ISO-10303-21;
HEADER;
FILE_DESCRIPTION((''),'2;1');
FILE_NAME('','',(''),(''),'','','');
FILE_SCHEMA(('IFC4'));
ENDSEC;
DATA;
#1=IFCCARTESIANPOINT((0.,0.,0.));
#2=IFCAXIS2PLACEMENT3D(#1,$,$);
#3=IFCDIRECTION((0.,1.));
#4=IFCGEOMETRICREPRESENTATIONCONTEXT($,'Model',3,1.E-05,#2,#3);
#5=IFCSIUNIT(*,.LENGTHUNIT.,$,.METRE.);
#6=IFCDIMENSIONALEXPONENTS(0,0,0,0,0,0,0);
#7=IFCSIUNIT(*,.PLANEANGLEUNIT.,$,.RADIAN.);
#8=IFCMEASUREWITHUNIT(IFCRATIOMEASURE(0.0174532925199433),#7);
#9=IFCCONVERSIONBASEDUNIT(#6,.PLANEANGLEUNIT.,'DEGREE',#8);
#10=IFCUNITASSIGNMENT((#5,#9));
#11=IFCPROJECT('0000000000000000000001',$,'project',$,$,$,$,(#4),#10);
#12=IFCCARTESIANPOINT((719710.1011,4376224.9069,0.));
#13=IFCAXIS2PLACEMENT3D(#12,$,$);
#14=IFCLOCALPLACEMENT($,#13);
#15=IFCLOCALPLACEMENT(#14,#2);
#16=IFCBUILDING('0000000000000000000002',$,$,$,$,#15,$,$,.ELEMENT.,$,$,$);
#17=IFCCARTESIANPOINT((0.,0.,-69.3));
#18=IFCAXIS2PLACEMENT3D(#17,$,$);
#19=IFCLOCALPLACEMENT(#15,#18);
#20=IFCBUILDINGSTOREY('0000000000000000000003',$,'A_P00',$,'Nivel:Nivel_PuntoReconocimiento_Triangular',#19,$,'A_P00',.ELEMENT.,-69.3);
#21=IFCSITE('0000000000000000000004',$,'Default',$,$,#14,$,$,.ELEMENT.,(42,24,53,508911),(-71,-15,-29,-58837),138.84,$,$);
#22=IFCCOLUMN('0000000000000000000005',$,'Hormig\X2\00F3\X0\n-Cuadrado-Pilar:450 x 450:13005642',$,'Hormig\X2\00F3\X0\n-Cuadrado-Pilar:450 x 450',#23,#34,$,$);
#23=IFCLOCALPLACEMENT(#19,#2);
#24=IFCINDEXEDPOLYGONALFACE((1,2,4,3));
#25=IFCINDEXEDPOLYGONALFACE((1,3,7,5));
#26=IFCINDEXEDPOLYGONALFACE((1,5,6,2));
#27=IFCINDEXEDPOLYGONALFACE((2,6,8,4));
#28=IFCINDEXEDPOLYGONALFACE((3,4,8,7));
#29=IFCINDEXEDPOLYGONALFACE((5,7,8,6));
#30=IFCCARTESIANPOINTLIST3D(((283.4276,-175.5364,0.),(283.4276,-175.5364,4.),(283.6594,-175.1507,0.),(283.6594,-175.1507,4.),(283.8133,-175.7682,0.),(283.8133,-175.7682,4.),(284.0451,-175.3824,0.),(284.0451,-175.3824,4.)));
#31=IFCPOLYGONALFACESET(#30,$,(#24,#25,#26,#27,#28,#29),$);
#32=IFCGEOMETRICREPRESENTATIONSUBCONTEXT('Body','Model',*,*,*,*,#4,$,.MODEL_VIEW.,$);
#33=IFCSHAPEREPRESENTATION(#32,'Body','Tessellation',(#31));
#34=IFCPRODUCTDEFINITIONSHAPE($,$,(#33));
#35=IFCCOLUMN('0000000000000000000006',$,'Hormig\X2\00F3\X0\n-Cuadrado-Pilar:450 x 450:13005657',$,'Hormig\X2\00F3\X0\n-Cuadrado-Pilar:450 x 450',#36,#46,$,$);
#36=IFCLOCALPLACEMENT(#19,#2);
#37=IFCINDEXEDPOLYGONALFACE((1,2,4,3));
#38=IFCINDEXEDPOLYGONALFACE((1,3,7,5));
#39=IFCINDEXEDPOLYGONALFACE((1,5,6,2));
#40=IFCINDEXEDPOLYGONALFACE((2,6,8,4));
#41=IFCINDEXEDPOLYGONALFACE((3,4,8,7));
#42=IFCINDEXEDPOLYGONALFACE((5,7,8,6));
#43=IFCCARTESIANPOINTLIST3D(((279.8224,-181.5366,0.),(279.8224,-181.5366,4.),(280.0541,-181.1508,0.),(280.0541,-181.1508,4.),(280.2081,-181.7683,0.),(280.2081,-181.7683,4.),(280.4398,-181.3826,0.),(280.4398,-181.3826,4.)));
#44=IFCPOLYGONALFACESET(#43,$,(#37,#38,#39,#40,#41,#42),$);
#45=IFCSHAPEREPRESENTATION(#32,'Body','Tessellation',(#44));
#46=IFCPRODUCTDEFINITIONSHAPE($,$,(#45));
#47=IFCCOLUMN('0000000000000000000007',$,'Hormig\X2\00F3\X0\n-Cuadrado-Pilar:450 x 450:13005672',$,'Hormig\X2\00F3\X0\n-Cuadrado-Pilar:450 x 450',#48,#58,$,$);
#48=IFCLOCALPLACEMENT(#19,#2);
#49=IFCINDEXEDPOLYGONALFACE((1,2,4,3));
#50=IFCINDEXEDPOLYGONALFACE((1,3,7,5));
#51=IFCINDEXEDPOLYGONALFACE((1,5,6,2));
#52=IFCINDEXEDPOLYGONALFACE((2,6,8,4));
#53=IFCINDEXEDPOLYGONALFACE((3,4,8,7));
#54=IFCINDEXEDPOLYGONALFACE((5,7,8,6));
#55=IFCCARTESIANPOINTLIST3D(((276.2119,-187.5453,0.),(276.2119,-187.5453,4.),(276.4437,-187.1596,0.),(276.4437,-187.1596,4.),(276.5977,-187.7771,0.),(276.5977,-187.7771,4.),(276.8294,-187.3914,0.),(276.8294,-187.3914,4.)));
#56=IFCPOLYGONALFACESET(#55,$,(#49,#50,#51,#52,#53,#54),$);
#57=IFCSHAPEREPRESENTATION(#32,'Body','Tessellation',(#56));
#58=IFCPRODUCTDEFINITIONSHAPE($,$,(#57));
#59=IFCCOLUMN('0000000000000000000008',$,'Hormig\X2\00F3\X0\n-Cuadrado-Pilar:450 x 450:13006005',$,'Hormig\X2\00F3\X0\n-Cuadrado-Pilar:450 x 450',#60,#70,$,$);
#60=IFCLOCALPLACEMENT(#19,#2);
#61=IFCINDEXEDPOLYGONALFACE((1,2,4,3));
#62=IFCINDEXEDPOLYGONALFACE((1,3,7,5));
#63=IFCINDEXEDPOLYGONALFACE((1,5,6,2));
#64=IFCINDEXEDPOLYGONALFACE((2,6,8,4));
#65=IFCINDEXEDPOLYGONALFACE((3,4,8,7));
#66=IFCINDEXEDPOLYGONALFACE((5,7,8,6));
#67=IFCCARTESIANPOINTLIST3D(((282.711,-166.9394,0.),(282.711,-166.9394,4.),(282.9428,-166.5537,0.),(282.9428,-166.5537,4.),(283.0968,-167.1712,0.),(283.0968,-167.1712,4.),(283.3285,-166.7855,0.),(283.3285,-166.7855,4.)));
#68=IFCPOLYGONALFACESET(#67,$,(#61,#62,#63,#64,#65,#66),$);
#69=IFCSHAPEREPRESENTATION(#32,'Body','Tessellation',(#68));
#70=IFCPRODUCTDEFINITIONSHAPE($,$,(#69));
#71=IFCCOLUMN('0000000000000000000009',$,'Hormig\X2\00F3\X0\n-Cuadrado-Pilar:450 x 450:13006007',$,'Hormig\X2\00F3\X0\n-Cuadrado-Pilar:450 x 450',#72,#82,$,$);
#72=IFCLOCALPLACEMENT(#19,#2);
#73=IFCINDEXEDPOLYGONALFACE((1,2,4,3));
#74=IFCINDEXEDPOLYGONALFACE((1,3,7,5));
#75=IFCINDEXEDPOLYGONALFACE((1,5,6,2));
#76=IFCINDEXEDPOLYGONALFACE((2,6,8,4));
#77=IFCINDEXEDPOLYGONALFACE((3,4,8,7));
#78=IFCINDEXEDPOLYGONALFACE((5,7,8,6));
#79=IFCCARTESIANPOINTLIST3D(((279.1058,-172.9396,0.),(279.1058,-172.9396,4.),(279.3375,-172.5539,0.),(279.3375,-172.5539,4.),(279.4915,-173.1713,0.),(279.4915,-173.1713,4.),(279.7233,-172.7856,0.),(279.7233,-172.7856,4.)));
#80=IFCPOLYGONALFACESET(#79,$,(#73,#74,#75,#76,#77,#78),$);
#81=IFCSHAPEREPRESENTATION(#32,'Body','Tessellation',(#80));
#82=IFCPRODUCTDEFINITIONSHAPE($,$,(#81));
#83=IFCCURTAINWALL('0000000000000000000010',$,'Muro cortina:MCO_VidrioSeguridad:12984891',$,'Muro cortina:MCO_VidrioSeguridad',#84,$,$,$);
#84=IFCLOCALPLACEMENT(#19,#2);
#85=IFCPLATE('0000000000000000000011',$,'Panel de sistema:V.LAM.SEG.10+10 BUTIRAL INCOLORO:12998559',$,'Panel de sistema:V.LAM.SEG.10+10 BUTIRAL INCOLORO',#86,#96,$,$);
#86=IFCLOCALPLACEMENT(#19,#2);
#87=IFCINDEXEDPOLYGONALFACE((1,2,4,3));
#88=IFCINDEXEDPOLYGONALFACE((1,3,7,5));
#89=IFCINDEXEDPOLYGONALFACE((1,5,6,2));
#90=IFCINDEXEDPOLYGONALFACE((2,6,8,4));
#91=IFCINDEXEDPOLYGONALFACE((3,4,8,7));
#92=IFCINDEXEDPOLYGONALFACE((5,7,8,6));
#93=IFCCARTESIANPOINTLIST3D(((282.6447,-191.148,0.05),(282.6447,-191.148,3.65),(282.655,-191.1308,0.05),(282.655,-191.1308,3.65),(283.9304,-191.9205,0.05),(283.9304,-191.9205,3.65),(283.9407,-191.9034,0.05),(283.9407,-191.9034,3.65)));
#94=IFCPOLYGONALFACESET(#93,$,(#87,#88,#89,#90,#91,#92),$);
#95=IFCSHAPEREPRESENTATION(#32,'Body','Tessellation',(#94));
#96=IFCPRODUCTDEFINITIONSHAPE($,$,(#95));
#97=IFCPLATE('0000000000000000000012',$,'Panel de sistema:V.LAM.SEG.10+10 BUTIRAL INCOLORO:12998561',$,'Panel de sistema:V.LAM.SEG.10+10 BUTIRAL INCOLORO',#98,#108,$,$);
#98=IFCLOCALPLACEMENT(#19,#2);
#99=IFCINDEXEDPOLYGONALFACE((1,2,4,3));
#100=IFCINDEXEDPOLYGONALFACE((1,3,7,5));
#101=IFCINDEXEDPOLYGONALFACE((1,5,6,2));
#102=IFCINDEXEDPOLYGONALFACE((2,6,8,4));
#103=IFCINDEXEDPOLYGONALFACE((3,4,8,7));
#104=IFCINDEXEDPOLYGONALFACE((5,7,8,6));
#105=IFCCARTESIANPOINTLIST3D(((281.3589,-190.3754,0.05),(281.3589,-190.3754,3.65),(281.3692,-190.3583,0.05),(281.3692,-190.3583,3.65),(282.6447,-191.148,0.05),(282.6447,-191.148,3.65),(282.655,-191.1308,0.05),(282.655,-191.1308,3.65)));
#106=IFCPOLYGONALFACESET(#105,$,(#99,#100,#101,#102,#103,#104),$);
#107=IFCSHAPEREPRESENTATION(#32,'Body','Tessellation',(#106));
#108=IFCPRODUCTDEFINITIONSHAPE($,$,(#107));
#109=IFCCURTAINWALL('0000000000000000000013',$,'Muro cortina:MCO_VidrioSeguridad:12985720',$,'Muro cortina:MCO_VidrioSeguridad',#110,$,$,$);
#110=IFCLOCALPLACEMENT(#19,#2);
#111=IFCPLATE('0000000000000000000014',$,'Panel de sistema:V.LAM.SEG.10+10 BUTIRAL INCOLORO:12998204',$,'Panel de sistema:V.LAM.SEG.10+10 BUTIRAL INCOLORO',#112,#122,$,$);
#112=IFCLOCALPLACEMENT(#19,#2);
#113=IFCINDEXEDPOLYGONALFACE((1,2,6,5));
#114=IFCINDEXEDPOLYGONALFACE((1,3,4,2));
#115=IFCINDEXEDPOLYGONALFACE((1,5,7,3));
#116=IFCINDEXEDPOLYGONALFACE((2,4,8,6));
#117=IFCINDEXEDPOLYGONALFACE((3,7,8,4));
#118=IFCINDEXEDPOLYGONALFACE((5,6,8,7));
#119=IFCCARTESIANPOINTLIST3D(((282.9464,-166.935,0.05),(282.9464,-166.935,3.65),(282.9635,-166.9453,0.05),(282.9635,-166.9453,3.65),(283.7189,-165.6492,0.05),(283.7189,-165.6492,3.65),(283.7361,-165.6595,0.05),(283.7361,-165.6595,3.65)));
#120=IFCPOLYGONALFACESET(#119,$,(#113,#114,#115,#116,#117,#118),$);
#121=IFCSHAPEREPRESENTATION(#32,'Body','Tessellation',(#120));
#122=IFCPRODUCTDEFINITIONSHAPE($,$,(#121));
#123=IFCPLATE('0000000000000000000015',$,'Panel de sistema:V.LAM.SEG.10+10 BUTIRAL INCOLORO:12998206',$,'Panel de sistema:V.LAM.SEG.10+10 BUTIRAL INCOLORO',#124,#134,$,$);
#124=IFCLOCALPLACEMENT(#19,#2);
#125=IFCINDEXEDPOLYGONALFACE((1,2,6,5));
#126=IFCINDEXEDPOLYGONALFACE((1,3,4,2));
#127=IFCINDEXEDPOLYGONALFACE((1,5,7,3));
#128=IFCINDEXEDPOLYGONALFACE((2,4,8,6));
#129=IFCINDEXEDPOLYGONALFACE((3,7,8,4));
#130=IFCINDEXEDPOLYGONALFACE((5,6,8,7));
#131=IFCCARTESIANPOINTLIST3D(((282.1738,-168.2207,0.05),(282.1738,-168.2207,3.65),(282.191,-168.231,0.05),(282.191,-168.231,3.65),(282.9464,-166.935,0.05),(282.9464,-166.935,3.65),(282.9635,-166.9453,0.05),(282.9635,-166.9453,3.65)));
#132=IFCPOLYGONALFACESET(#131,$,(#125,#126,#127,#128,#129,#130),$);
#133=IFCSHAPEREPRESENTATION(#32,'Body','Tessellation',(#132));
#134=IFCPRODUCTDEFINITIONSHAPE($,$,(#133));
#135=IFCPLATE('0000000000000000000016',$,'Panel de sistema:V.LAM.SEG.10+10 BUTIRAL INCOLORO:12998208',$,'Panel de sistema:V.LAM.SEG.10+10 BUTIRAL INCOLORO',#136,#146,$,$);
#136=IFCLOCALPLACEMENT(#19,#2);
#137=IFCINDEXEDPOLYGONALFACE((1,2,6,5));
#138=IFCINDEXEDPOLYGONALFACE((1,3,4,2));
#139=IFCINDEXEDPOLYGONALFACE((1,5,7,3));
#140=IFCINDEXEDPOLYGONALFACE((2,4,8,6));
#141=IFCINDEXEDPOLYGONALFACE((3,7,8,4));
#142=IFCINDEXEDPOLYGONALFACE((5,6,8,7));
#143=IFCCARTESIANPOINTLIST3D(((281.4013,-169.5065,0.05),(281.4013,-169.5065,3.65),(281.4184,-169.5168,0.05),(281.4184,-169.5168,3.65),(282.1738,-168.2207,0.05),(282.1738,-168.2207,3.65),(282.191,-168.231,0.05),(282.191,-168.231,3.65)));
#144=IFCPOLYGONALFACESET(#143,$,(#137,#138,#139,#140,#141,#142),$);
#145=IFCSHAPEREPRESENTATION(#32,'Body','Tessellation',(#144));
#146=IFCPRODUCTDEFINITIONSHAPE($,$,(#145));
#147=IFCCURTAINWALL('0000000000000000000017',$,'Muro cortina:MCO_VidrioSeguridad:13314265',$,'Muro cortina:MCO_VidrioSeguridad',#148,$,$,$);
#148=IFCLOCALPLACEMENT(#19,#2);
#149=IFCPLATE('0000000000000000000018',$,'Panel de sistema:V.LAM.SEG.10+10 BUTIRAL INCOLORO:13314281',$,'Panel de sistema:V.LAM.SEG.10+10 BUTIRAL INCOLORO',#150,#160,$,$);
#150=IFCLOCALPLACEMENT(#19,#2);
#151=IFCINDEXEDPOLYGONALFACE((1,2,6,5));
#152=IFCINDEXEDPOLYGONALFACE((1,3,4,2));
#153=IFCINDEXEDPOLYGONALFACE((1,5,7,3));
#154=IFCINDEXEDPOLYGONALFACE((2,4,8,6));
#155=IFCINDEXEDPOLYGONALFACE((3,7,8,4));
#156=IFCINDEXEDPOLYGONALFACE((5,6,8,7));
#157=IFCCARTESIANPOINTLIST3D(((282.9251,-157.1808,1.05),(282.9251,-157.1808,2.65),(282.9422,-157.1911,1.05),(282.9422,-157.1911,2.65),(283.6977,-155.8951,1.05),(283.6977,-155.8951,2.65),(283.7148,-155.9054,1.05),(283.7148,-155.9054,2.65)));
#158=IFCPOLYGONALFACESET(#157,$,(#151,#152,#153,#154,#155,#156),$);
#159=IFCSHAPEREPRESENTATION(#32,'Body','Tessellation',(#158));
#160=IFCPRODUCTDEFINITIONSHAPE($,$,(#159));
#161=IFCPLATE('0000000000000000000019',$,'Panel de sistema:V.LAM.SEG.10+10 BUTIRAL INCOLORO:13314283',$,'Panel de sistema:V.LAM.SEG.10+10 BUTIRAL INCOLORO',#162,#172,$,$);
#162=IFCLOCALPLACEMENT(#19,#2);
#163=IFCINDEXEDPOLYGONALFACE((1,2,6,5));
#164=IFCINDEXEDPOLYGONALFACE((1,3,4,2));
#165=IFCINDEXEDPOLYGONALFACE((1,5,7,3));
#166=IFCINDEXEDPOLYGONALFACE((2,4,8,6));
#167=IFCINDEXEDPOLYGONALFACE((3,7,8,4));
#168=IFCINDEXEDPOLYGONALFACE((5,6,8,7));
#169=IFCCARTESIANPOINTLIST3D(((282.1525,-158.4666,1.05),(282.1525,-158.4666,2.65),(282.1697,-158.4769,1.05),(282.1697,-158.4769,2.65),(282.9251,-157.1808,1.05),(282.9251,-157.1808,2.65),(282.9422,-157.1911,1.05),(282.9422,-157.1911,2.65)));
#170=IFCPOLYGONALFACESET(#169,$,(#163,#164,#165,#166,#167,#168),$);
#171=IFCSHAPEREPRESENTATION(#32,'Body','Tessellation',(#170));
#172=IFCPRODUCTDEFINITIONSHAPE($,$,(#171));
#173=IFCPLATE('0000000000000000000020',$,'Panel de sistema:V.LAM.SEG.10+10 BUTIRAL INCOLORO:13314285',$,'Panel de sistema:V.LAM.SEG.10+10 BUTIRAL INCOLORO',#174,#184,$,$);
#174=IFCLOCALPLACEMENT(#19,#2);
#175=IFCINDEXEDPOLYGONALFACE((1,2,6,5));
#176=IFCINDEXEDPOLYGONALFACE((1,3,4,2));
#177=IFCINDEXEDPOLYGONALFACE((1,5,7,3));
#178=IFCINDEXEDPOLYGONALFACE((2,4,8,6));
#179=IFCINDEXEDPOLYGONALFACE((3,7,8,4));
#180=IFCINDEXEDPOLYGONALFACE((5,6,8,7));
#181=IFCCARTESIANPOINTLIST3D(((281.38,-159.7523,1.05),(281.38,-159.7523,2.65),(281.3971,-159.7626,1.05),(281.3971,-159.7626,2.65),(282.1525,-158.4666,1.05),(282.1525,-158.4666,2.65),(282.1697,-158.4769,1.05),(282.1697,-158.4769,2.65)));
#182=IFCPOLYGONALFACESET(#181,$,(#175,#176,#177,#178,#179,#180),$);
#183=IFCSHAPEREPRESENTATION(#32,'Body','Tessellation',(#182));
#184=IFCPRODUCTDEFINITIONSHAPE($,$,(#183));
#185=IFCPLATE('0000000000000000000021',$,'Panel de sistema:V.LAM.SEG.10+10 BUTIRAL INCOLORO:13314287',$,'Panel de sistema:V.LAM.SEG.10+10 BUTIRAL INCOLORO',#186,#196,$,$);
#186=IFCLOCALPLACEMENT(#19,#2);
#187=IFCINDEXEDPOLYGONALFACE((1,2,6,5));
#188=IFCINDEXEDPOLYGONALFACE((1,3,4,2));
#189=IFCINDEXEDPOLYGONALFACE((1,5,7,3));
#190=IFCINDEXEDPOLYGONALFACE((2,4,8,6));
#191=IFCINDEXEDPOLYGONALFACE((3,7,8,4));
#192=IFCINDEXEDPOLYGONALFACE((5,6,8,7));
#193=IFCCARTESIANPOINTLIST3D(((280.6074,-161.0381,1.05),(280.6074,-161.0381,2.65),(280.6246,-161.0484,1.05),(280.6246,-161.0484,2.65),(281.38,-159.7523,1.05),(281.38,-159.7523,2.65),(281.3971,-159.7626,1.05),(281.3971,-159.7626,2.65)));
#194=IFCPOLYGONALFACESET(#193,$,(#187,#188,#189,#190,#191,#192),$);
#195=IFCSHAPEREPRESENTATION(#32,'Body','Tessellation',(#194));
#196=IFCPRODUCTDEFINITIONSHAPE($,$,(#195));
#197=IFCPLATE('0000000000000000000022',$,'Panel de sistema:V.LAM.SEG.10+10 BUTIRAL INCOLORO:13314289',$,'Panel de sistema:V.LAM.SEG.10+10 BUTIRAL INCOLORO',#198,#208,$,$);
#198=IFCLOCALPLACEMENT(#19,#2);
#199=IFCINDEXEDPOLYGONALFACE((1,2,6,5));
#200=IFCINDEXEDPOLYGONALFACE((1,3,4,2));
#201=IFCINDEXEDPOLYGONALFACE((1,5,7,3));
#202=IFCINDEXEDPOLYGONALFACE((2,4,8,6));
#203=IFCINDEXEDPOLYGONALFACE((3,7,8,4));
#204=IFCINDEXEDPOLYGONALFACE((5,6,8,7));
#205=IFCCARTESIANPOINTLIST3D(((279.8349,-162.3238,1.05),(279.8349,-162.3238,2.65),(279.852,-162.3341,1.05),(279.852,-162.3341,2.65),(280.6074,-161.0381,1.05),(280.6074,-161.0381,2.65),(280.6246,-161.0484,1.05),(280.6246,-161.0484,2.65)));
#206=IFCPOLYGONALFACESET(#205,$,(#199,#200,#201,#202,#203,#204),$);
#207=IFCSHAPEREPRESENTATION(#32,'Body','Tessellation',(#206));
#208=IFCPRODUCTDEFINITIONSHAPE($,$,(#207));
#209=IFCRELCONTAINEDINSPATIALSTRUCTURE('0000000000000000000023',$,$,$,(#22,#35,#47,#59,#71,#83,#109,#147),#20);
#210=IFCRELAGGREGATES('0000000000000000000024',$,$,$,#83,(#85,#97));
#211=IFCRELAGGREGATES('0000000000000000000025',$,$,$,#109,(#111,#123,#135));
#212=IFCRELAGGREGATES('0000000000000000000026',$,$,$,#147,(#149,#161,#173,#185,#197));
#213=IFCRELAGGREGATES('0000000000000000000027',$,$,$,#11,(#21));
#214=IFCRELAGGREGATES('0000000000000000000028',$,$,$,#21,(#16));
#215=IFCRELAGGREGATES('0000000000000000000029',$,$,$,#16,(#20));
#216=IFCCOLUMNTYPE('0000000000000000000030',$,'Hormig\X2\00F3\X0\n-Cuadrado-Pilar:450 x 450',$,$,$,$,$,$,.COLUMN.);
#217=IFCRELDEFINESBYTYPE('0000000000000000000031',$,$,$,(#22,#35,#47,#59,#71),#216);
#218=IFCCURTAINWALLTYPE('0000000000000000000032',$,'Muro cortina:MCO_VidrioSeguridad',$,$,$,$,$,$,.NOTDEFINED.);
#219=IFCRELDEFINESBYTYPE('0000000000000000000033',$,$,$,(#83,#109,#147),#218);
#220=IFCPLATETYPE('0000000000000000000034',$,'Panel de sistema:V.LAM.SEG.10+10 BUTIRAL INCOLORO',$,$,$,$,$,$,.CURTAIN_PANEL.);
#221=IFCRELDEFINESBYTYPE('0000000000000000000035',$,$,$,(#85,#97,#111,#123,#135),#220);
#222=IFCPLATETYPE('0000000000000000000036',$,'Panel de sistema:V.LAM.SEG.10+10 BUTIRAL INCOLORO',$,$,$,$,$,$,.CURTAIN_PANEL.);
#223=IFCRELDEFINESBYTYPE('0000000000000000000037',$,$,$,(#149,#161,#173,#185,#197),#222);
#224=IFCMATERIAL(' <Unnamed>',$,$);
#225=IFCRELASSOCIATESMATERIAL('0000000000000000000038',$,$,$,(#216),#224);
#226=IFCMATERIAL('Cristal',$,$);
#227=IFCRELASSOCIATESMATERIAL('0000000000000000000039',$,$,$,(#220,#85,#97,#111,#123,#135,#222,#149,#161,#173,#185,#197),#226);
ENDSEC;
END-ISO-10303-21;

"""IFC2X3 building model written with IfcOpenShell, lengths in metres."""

from ifc_helpers import new_model, entity, si_unit, converted_unit, direction, frame, frame_2d, origin, origin_2d_with_axis, place, context, subcontext, project, spatial, rectangle, extrude, source, transform, mapped, material, type_object, type_shapes, element, aggregate, save


model = new_model("IFC2X3")

# Units and contexts
model_context = context("Model", 3, precision=1e-05, world=origin(), true_north=direction((0.0, 1.0)))
body_context = subcontext(model_context, "Body", "Model", "MODEL_VIEW")
ifc_project = project(units=[si_unit("LENGTHUNIT", "METRE"), converted_unit("PLANEANGLEUNIT", "DEGREE", entity("IfcRatioMeasure", 0.0174532925199433), si_unit("PLANEANGLEUNIT", "RADIAN"), dimensions=[0, 0, 0, 0, 0, 0, 0])], contexts=[model_context])

# Site, building, storey
site_placement = place(None, frame((719710.1011, 4376224.9069, 0.0)))
site = spatial("IfcSite", under=ifc_project, at=site_placement, Name="Default", CompositionType="ELEMENT", RefLatitude=(42, 24, 53, 508911), RefLongitude=(-71, -15, -29, -58837), RefElevation=138.84)
building_placement = place(site_placement, origin())
building = spatial("IfcBuilding", under=site, at=building_placement, CompositionType="ELEMENT")
storey_placement = place(building_placement, frame((0.0, 0.0, -69.3)))
storey = spatial("IfcBuildingStorey", under=building, at=storey_placement, Name="A_P00", ObjectType="Nivel:Nivel_PuntoReconocimiento_Triangular", LongName="A_P00", CompositionType="ELEMENT", Elevation=-69.3)

# Columns
ifc_material_1 = material(Name=" <Unnamed>")
column_type = type_object("IfcColumnType", Name="Hormigón-Cuadrado-Pilar:450 x 450", PredefinedType="COLUMN", material=ifc_material_1)
shared_shape_1 = source(origin(), body_context, "Body", "SweptSolid", [
    extrude(rectangle(XDim=0.45, YDim=0.45, at=origin_2d_with_axis()), frame((0.0, 0.0, -69.3), z_axis=(0.0, 0.0, 1.0), x_axis=(0.0, -1.0, 0.0)), (0.0, 0.0, 1.0), 4.0),
])
type_shapes(column_type, [shared_shape_1])
for number, where, z_axis, x_axis, name in (
    (1, (283.7364, -175.4594, 69.3), (0.0, 0.0, 1.0), (0.857167, -0.515038, 0.0), "Hormigón-Cuadrado-Pilar:450 x 450:13005642"),
    (2, (280.1311, -181.4596, 69.3), (0.0, 0.0, 1.0), (0.857167, -0.515038, 0.0), "Hormigón-Cuadrado-Pilar:450 x 450:13005657"),
    (3, (276.5207, -187.4683, 69.3), (0.0, 0.0, 1.0), (0.857167, -0.515038, 0.0), "Hormigón-Cuadrado-Pilar:450 x 450:13005672"),
    (4, (283.0198, -166.8624, 69.3), (0.0, 0.0, 1.0), (0.857167, -0.515038, 0.0), "Hormigón-Cuadrado-Pilar:450 x 450:13006005"),
    (5, (279.4145, -172.8626, 69.3), (0.0, 0.0, 1.0), (0.857167, -0.515038, 0.0), "Hormigón-Cuadrado-Pilar:450 x 450:13006007"),
):
    element("IfcColumn", number, at=place(storey_placement, frame(where, z_axis=z_axis, x_axis=x_axis)), inside=storey, type_object=column_type, Name=name, ObjectType="Hormigón-Cuadrado-Pilar:450 x 450", context=body_context, shape_type="MappedRepresentation", body=[
        mapped(shared_shape_1, transform((0.0, 0.0, 0.0), scale=1.0)),
    ])

# Curtain walls, plates
curtain_wall_type = type_object("IfcCurtainWallType", Name="Muro cortina:MCO_VidrioSeguridad", PredefinedType="NOTDEFINED")
curtain_wall_1_placement = place(storey_placement, frame((0.0, 0.0, 69.3)))
curtain_wall_1 = element("IfcCurtainWall", 6, at=curtain_wall_1_placement, inside=storey, type_object=curtain_wall_type, Name="Muro cortina:MCO_VidrioSeguridad:12984891", ObjectType="Muro cortina:MCO_VidrioSeguridad")
ifc_material_2 = material(Name="Cristal")
plate_type_1 = type_object("IfcPlateType", Name="Panel de sistema:V.LAM.SEG.10+10 BUTIRAL INCOLORO", PredefinedType="CURTAIN_PANEL", material=ifc_material_2)
shared_shape_2 = source(origin(), body_context, "Body", "SweptSolid", [
    extrude(rectangle(XDim=0.02, YDim=1.5, at=origin_2d_with_axis()), frame((0.0, 0.0, 0.0), z_axis=(0.0, 0.0, 1.0), x_axis=(0.0, 1.0, 0.0)), (0.0, 0.0, 1.0), 3.6),
])
type_shapes(plate_type_1, [shared_shape_2])
plate_1_placement = place(curtain_wall_1_placement, frame((283.2927, -191.5257, -69.25), z_axis=(0.0, 0.0, 1.0), x_axis=(-0.857167, 0.515038, 0.0)))
plate_1 = element("IfcPlate", 7, at=plate_1_placement, type_object=plate_type_1, material=ifc_material_2, Name="Panel de sistema:V.LAM.SEG.10+10 BUTIRAL INCOLORO:12998559", ObjectType="Panel de sistema:V.LAM.SEG.10+10 BUTIRAL INCOLORO", context=body_context, shape_type="MappedRepresentation", body=[
    mapped(shared_shape_2, transform((0.0, 0.0, 0.0), scale=1.0)),
])
plate_2_placement = place(curtain_wall_1_placement, frame((282.0069, -190.7531, -69.25), z_axis=(0.0, 0.0, 1.0), x_axis=(-0.857167, 0.515038, 0.0)))
plate_2 = element("IfcPlate", 8, at=plate_2_placement, type_object=plate_type_1, material=ifc_material_2, Name="Panel de sistema:V.LAM.SEG.10+10 BUTIRAL INCOLORO:12998561", ObjectType="Panel de sistema:V.LAM.SEG.10+10 BUTIRAL INCOLORO", context=body_context, shape_type="MappedRepresentation", body=[
    mapped(shared_shape_2, transform((0.0, 0.0, 0.0), scale=1.0)),
])
aggregate(curtain_wall_1, [plate_1, plate_2])
curtain_wall_2_placement = place(storey_placement, frame((0.0, 0.0, 69.3)))
curtain_wall_2 = element("IfcCurtainWall", 9, at=curtain_wall_2_placement, inside=storey, type_object=curtain_wall_type, Name="Muro cortina:MCO_VidrioSeguridad:12985720", ObjectType="Muro cortina:MCO_VidrioSeguridad")
plate_3_placement = place(curtain_wall_2_placement, frame((283.3412, -166.2973, -69.25), z_axis=(0.0, 0.0, 1.0), x_axis=(-0.515038, -0.857167, 0.0)))
plate_3 = element("IfcPlate", 10, at=plate_3_placement, type_object=plate_type_1, material=ifc_material_2, Name="Panel de sistema:V.LAM.SEG.10+10 BUTIRAL INCOLORO:12998204", ObjectType="Panel de sistema:V.LAM.SEG.10+10 BUTIRAL INCOLORO", context=body_context, shape_type="MappedRepresentation", body=[
    mapped(shared_shape_2, transform((0.0, 0.0, 0.0), scale=1.0)),
])
plate_4_placement = place(curtain_wall_2_placement, frame((282.5687, -167.583, -69.25), z_axis=(0.0, 0.0, 1.0), x_axis=(-0.515038, -0.857167, 0.0)))
plate_4 = element("IfcPlate", 11, at=plate_4_placement, type_object=plate_type_1, material=ifc_material_2, Name="Panel de sistema:V.LAM.SEG.10+10 BUTIRAL INCOLORO:12998206", ObjectType="Panel de sistema:V.LAM.SEG.10+10 BUTIRAL INCOLORO", context=body_context, shape_type="MappedRepresentation", body=[
    mapped(shared_shape_2, transform((0.0, 0.0, 0.0), scale=1.0)),
])
plate_5_placement = place(curtain_wall_2_placement, frame((281.7961, -168.8688, -69.25), z_axis=(0.0, 0.0, 1.0), x_axis=(-0.515038, -0.857167, 0.0)))
plate_5 = element("IfcPlate", 12, at=plate_5_placement, type_object=plate_type_1, material=ifc_material_2, Name="Panel de sistema:V.LAM.SEG.10+10 BUTIRAL INCOLORO:12998208", ObjectType="Panel de sistema:V.LAM.SEG.10+10 BUTIRAL INCOLORO", context=body_context, shape_type="MappedRepresentation", body=[
    mapped(shared_shape_2, transform((0.0, 0.0, 0.0), scale=1.0)),
])
aggregate(curtain_wall_2, [plate_3, plate_4, plate_5])
curtain_wall_3_placement = place(storey_placement, frame((0.0, 0.0, 69.3)))
curtain_wall_3 = element("IfcCurtainWall", 13, at=curtain_wall_3_placement, inside=storey, type_object=curtain_wall_type, Name="Muro cortina:MCO_VidrioSeguridad:13314265", ObjectType="Muro cortina:MCO_VidrioSeguridad")
plate_type_2 = type_object("IfcPlateType", Name="Panel de sistema:V.LAM.SEG.10+10 BUTIRAL INCOLORO", PredefinedType="CURTAIN_PANEL", material=ifc_material_2)
shared_shape_3 = source(origin(), body_context, "Body", "SweptSolid", [
    extrude(rectangle(XDim=0.02, YDim=1.5, at=frame_2d((0.0, 0.0), x_axis=(1.0, 0.0))), frame((0.0, 0.0, 0.0), z_axis=(0.0, 0.0, 1.0), x_axis=(0.0, 1.0, 0.0)), (0.0, 0.0, 1.0), 1.6),
])
type_shapes(plate_type_2, [shared_shape_3])
plate_6_placement = place(curtain_wall_3_placement, frame((283.32, -156.5431, -68.25), z_axis=(0.0, 0.0, 1.0), x_axis=(-0.515038, -0.857167, 0.0)))
plate_6 = element("IfcPlate", 14, at=plate_6_placement, type_object=plate_type_2, material=ifc_material_2, Name="Panel de sistema:V.LAM.SEG.10+10 BUTIRAL INCOLORO:13314281", ObjectType="Panel de sistema:V.LAM.SEG.10+10 BUTIRAL INCOLORO", context=body_context, shape_type="MappedRepresentation", body=[
    mapped(shared_shape_3, transform((0.0, 0.0, 0.0), scale=1.0)),
])
plate_7_placement = place(curtain_wall_3_placement, frame((282.5474, -157.8288, -68.25), z_axis=(0.0, 0.0, 1.0), x_axis=(-0.515038, -0.857167, 0.0)))
plate_7 = element("IfcPlate", 15, at=plate_7_placement, type_object=plate_type_2, material=ifc_material_2, Name="Panel de sistema:V.LAM.SEG.10+10 BUTIRAL INCOLORO:13314283", ObjectType="Panel de sistema:V.LAM.SEG.10+10 BUTIRAL INCOLORO", context=body_context, shape_type="MappedRepresentation", body=[
    mapped(shared_shape_3, transform((0.0, 0.0, 0.0), scale=1.0)),
])
plate_8_placement = place(curtain_wall_3_placement, frame((281.7748, -159.1146, -68.25), z_axis=(0.0, 0.0, 1.0), x_axis=(-0.515038, -0.857167, 0.0)))
plate_8 = element("IfcPlate", 16, at=plate_8_placement, type_object=plate_type_2, material=ifc_material_2, Name="Panel de sistema:V.LAM.SEG.10+10 BUTIRAL INCOLORO:13314285", ObjectType="Panel de sistema:V.LAM.SEG.10+10 BUTIRAL INCOLORO", context=body_context, shape_type="MappedRepresentation", body=[
    mapped(shared_shape_3, transform((0.0, 0.0, 0.0), scale=1.0)),
])
plate_9_placement = place(curtain_wall_3_placement, frame((281.0023, -160.4003, -68.25), z_axis=(0.0, 0.0, 1.0), x_axis=(-0.515038, -0.857167, 0.0)))
plate_9 = element("IfcPlate", 17, at=plate_9_placement, type_object=plate_type_2, material=ifc_material_2, Name="Panel de sistema:V.LAM.SEG.10+10 BUTIRAL INCOLORO:13314287", ObjectType="Panel de sistema:V.LAM.SEG.10+10 BUTIRAL INCOLORO", context=body_context, shape_type="MappedRepresentation", body=[
    mapped(shared_shape_3, transform((0.0, 0.0, 0.0), scale=1.0)),
])
plate_10_placement = place(curtain_wall_3_placement, frame((280.2297, -161.6861, -68.25), z_axis=(0.0, 0.0, 1.0), x_axis=(-0.515038, -0.857167, 0.0)))
plate_10 = element("IfcPlate", 18, at=plate_10_placement, type_object=plate_type_2, material=ifc_material_2, Name="Panel de sistema:V.LAM.SEG.10+10 BUTIRAL INCOLORO:13314289", ObjectType="Panel de sistema:V.LAM.SEG.10+10 BUTIRAL INCOLORO", context=body_context, shape_type="MappedRepresentation", body=[
    mapped(shared_shape_3, transform((0.0, 0.0, 0.0), scale=1.0)),
])
aggregate(curtain_wall_3, [plate_6, plate_7, plate_8, plate_9, plate_10])

save(model, "model.ifc")
